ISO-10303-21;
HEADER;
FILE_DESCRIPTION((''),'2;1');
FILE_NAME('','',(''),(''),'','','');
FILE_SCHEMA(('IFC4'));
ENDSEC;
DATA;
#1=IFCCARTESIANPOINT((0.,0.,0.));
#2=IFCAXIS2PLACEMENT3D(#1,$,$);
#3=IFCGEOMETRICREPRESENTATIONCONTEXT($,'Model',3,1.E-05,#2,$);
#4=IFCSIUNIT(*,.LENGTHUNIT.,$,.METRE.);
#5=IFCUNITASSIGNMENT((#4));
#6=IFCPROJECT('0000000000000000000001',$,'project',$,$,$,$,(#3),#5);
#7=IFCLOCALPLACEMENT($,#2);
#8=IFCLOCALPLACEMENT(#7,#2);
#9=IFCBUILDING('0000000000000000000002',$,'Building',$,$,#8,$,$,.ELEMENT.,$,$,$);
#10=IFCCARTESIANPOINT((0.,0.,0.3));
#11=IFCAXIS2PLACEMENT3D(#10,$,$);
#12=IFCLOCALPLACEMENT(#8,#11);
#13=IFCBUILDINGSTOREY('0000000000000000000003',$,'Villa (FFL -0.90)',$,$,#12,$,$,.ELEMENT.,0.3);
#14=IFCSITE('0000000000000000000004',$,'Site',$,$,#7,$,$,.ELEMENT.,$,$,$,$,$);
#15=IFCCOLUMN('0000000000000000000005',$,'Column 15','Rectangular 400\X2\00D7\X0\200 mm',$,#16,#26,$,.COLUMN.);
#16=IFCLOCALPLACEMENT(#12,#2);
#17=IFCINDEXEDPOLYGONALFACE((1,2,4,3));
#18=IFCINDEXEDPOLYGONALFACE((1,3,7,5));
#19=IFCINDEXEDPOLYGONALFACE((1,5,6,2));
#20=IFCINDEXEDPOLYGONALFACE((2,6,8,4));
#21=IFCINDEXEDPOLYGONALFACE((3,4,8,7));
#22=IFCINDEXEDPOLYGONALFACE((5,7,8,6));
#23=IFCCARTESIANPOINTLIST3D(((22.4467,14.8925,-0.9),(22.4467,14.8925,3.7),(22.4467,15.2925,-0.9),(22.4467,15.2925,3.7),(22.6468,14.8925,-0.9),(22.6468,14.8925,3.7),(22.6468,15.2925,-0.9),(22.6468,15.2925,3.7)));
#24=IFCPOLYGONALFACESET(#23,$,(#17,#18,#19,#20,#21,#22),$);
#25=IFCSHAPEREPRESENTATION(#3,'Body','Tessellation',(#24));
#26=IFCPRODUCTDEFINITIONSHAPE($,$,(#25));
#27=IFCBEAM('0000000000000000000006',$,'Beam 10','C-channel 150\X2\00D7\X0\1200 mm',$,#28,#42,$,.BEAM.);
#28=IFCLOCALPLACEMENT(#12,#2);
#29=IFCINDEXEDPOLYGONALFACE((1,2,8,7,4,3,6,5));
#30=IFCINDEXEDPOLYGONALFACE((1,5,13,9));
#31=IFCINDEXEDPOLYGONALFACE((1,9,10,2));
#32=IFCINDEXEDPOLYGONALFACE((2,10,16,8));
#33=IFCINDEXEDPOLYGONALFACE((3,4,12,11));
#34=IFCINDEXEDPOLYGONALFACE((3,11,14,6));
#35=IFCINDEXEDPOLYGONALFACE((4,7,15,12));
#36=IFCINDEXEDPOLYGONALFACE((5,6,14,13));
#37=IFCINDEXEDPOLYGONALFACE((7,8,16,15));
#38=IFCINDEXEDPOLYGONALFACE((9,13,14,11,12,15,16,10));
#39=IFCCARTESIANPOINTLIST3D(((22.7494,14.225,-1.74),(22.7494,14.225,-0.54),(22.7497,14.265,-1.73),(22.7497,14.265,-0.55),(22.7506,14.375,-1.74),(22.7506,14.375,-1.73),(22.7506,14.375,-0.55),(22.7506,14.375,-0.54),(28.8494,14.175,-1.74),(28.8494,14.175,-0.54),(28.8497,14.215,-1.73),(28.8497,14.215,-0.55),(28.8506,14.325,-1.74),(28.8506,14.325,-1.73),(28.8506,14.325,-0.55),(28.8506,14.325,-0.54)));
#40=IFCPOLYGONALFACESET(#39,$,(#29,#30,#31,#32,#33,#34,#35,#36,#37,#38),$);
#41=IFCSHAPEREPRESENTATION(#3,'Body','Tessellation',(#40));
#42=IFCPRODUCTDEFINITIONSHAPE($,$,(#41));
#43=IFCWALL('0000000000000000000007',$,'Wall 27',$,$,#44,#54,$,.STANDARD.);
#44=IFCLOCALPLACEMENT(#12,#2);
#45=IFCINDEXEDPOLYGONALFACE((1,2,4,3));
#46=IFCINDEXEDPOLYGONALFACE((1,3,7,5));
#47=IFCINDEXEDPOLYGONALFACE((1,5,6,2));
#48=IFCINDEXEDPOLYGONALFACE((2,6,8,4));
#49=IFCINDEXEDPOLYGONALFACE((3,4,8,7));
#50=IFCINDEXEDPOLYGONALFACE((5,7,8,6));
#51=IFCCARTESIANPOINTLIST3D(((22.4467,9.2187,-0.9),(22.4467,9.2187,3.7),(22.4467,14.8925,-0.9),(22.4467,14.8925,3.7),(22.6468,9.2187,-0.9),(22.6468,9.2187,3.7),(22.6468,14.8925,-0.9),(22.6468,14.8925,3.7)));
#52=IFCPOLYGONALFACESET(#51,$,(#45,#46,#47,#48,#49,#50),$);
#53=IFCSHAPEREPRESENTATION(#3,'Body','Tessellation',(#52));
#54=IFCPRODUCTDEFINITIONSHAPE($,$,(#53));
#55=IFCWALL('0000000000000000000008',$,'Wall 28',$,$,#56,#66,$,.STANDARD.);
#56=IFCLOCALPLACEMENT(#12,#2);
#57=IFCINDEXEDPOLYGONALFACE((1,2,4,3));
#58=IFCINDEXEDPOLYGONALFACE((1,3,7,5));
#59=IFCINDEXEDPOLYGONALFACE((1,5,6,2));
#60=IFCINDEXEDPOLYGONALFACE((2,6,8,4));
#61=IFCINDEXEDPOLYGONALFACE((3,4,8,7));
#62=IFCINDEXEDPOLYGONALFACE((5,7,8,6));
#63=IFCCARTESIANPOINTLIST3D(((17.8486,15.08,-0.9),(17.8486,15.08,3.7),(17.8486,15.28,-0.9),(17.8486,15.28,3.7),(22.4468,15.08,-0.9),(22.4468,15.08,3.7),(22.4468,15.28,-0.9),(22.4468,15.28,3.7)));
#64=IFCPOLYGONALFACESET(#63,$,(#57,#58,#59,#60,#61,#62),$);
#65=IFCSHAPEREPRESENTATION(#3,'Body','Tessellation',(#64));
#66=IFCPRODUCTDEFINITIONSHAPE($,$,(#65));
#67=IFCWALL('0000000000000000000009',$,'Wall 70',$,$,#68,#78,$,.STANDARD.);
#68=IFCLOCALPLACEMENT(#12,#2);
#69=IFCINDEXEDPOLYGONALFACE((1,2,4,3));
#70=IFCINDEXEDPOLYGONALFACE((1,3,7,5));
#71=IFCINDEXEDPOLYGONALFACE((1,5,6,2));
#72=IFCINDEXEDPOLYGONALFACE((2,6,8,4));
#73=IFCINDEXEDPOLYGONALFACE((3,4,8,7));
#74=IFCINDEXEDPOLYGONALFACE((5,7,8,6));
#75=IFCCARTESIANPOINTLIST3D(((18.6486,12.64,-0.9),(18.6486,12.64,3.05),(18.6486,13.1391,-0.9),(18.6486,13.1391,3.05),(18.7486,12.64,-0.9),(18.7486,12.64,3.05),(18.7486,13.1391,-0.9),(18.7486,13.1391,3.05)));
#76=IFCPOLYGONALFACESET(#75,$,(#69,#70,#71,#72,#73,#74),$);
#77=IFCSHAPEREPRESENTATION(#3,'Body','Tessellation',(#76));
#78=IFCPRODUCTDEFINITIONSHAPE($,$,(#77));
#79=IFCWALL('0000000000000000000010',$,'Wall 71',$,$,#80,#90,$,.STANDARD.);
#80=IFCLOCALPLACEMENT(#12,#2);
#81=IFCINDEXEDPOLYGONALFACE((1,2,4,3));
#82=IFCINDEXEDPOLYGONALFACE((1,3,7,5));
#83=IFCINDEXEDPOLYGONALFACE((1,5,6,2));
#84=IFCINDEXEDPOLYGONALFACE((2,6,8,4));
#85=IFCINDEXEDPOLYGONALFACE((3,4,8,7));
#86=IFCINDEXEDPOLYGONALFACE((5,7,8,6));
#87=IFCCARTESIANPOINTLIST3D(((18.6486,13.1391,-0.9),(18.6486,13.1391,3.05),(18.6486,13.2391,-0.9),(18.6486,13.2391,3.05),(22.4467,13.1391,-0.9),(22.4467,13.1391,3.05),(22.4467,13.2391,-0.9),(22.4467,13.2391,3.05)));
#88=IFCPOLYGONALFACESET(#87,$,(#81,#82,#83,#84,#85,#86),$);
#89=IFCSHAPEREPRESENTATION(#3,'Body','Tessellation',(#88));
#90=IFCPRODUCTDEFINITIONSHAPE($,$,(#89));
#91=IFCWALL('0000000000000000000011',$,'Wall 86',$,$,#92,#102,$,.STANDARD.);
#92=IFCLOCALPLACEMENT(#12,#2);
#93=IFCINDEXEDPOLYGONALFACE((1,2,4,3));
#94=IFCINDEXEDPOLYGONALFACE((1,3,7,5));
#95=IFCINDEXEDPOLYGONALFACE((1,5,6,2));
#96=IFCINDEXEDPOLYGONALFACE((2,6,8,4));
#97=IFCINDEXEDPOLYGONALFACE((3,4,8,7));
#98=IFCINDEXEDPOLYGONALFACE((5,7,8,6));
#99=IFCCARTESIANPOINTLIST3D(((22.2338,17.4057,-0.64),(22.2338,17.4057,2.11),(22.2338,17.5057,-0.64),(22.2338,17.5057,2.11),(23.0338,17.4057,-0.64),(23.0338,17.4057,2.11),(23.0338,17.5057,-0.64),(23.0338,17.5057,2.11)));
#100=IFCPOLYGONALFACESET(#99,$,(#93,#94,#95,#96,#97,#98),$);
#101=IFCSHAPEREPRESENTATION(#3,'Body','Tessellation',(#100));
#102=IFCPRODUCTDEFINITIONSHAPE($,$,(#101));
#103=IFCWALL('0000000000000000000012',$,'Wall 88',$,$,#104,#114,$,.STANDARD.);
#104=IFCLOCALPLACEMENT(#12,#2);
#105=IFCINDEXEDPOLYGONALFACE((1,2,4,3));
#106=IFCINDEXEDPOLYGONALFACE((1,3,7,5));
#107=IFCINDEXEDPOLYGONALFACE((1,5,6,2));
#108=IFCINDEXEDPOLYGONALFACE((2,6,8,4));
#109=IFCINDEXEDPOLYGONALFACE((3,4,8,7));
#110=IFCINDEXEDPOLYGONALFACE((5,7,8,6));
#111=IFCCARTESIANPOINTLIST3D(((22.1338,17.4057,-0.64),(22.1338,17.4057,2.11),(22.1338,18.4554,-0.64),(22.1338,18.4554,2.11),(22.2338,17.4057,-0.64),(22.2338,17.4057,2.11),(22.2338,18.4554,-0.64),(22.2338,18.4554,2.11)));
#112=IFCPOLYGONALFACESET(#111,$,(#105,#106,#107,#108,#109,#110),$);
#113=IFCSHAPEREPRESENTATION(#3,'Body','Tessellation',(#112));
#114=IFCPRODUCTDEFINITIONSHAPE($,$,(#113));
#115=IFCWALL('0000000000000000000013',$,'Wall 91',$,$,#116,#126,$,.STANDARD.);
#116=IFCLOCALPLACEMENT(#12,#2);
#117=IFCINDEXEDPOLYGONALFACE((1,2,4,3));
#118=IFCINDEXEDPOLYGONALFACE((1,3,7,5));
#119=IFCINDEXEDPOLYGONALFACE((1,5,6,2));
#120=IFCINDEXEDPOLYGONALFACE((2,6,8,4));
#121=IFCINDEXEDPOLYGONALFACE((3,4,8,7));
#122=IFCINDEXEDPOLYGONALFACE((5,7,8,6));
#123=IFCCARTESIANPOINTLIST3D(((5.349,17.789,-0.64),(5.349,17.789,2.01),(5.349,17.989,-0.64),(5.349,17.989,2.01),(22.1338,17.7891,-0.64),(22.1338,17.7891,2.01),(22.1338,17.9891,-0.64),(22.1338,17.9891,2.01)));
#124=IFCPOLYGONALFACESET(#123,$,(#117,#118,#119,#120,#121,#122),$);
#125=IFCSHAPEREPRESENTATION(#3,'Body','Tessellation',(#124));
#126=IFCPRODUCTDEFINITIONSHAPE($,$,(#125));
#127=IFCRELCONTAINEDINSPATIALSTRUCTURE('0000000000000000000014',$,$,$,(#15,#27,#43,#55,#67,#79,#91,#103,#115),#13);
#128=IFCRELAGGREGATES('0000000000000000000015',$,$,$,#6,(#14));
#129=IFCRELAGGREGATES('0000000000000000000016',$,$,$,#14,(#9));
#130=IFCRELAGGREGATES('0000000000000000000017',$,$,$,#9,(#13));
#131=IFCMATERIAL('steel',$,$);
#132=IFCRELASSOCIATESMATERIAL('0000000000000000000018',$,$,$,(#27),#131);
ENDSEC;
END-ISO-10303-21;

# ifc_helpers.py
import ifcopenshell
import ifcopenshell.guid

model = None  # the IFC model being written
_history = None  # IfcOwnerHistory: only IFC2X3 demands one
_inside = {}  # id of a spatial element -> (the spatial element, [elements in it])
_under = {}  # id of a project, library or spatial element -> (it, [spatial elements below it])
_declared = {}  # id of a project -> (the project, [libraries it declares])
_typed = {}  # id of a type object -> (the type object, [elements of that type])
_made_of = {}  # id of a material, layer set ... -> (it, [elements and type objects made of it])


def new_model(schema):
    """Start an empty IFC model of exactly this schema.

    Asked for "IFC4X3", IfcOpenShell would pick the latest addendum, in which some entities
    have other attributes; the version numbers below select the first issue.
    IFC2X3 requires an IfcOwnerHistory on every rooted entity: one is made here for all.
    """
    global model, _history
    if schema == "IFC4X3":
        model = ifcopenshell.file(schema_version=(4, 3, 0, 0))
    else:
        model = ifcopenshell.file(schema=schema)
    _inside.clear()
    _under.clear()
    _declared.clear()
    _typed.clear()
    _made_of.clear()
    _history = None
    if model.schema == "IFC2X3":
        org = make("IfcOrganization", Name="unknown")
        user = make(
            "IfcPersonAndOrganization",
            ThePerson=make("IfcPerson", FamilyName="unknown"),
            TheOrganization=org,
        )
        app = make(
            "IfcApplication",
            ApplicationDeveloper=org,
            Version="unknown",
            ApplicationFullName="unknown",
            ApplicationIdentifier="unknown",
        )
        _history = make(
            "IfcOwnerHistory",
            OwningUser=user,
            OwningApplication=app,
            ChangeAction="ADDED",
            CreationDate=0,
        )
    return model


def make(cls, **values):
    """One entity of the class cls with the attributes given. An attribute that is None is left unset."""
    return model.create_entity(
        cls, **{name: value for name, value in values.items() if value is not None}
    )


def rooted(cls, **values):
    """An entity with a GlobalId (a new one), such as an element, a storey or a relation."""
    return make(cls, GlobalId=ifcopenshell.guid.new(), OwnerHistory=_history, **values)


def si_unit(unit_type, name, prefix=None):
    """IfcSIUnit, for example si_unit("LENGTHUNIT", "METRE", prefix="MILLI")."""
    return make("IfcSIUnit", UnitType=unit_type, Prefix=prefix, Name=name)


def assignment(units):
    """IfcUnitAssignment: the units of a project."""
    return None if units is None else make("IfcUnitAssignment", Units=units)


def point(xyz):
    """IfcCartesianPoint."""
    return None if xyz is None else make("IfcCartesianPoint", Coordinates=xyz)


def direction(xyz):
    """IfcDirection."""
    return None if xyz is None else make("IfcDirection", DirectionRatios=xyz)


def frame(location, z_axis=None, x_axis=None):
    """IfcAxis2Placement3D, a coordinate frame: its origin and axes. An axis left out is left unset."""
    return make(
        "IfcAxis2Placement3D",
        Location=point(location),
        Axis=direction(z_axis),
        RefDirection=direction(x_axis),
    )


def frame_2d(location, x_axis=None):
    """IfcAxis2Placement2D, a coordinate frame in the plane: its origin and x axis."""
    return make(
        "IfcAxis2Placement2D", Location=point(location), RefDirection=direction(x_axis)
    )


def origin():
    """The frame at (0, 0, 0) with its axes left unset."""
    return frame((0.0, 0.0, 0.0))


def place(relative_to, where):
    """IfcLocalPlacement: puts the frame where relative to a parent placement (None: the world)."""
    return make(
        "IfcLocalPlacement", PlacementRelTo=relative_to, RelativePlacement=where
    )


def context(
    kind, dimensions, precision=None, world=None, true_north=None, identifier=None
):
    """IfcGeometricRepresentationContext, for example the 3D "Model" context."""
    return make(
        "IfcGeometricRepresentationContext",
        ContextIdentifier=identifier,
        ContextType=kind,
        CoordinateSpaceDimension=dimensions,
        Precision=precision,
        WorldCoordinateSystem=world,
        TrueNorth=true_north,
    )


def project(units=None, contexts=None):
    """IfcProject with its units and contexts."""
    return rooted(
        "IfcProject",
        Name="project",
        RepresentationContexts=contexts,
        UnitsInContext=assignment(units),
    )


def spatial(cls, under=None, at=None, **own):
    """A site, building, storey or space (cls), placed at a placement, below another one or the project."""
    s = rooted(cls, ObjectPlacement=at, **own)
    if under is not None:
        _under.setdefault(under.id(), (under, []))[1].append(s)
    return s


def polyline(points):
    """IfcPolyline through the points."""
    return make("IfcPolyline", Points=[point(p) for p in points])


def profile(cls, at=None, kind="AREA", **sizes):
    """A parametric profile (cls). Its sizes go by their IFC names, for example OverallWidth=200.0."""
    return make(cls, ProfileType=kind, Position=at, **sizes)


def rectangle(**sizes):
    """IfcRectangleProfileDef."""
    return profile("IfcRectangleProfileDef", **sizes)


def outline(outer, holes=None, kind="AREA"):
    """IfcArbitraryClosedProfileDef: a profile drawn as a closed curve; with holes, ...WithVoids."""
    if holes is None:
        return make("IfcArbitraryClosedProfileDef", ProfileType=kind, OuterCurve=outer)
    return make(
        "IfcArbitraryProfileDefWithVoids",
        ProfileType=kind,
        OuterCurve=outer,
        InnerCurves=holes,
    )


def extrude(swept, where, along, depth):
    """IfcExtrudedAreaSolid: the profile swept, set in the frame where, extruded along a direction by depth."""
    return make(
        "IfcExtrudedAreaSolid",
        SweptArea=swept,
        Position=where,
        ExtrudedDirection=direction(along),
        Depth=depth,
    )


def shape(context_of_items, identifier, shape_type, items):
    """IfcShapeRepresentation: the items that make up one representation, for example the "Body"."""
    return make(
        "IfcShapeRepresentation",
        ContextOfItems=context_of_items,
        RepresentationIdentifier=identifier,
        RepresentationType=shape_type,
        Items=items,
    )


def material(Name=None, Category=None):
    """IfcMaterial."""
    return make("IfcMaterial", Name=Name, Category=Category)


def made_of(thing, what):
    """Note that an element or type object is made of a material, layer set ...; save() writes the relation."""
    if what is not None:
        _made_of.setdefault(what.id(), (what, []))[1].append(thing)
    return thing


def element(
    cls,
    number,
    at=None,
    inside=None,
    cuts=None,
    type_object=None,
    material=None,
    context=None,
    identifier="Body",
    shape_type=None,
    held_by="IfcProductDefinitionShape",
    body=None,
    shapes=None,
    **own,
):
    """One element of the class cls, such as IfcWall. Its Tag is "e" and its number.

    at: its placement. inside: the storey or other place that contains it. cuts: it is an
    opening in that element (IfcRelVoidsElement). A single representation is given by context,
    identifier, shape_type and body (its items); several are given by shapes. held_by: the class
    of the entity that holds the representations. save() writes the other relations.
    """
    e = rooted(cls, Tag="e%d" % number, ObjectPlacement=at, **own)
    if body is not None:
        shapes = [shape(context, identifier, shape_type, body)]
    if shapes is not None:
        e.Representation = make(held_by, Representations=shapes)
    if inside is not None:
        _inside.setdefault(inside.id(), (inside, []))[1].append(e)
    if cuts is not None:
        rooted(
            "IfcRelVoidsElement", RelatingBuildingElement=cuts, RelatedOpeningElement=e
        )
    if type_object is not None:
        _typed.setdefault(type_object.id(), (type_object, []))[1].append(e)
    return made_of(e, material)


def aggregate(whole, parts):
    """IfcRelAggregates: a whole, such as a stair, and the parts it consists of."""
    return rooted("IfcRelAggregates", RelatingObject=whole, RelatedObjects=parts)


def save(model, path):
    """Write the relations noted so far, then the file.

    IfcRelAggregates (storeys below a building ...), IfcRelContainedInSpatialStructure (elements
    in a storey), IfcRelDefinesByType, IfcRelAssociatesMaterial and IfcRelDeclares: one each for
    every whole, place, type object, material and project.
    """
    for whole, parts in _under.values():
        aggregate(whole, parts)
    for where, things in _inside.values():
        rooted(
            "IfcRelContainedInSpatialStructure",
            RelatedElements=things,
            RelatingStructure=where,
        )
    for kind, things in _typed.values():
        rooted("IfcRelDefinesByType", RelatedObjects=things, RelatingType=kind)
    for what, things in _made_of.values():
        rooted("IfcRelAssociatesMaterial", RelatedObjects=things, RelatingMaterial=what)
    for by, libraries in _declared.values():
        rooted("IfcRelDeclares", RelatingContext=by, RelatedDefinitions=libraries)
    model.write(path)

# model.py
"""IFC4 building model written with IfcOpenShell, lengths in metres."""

from ifc_helpers import new_model, si_unit, frame, frame_2d, origin, place, context, project, spatial, polyline, rectangle, outline, extrude, material, element, save


model = new_model("IFC4")

# Units and contexts
model_context = context("Model", 3, precision=1e-05, world=origin())
ifc_project = project(units=[si_unit("LENGTHUNIT", "METRE")], contexts=[model_context])

# Site, building, storey
site_placement = place(None, origin())
site = spatial("IfcSite", under=ifc_project, at=site_placement, Name="Site", CompositionType="ELEMENT")
building_placement = place(site_placement, origin())
building = spatial("IfcBuilding", under=site, at=building_placement, Name="Building", CompositionType="ELEMENT")
storey_placement = place(building_placement, frame((0.0, 0.0, 0.3)))
storey = spatial("IfcBuildingStorey", under=building, at=storey_placement, Name="Villa (FFL -0.90)", CompositionType="ELEMENT", Elevation=0.3)

# Column
column_placement = place(storey_placement, frame((22.5467, 15.0925, -0.9), z_axis=(0.0, 0.0, 1.0), x_axis=(0.0, 1.0, 0.0)))
element("IfcColumn", 1, at=column_placement, inside=storey, Name="Column 15", Description="Rectangular 400×200 mm", PredefinedType="COLUMN", context=model_context, shape_type="SweptSolid", body=[
    extrude(outline(polyline([(-0.2, -0.1), (0.2, -0.1), (0.2, 0.1), (-0.2, 0.1), (-0.2, -0.1)])), origin(), (0.0, 0.0, 1.0), 4.6),
])

# Beam
ifc_material = material(Name="steel")
beam_placement = place(storey_placement, frame((22.75, 14.3, -1.14), z_axis=(0.999966, -0.008196, 0.0), x_axis=(0.008196, 0.999966, 0.0)))
element("IfcBeam", 2, at=beam_placement, inside=storey, material=ifc_material, Name="Beam 10", Description="C-channel 150×1200 mm", PredefinedType="BEAM", context=model_context, shape_type="SweptSolid", body=[
    extrude(outline(polyline([(-0.075, -0.6), (0.075, -0.6), (0.075, -0.59), (-0.035, -0.59), (-0.035, 0.59), (0.075, 0.59), (0.075, 0.6), (-0.075, 0.6), (-0.075, -0.6)])), origin(), (0.0, 0.0, 1.0), 6.1002),
])

# Walls
wall_1_placement = place(storey_placement, frame((22.5467, 14.8925, -0.9), z_axis=(0.0, 0.0, 1.0), x_axis=(0.0, -1.0, 0.0)))
element("IfcWall", 3, at=wall_1_placement, inside=storey, Name="Wall 27", PredefinedType="STANDARD", context=model_context, shape_type="SweptSolid", body=[
    extrude(rectangle(XDim=5.6738, YDim=0.2, at=frame_2d((2.8369, 0.0))), origin(), (0.0, 0.0, 1.0), 4.6),
])
wall_2_placement = place(storey_placement, frame((17.8486, 15.18, -0.9), z_axis=(0.0, 0.0, 1.0), x_axis=(1.0, 0.0, 0.0)))
element("IfcWall", 4, at=wall_2_placement, inside=storey, Name="Wall 28", PredefinedType="STANDARD", context=model_context, shape_type="SweptSolid", body=[
    extrude(rectangle(XDim=4.5982, YDim=0.2, at=frame_2d((2.2991, 0.0))), origin(), (0.0, 0.0, 1.0), 4.6),
])
wall_3_placement = place(storey_placement, frame((18.6986, 13.1391, -0.9), z_axis=(0.0, 0.0, 1.0), x_axis=(0.0, -1.0, 0.0)))
element("IfcWall", 5, at=wall_3_placement, inside=storey, Name="Wall 70", PredefinedType="STANDARD", context=model_context, shape_type="SweptSolid", body=[
    extrude(rectangle(XDim=0.4991, YDim=0.1, at=frame_2d((0.2495, 0.0))), origin(), (0.0, 0.0, 1.0), 3.95),
])
wall_4_placement = place(storey_placement, frame((18.6486, 13.1891, -0.9), z_axis=(0.0, 0.0, 1.0), x_axis=(1.0, 0.0, 0.0)))
element("IfcWall", 6, at=wall_4_placement, inside=storey, Name="Wall 71", PredefinedType="STANDARD", context=model_context, shape_type="SweptSolid", body=[
    extrude(rectangle(XDim=3.7982, YDim=0.1, at=frame_2d((1.8991, 0.0))), origin(), (0.0, 0.0, 1.0), 3.95),
])

# Walls
wall_5_placement = place(storey_placement, frame((23.0338, 17.4557, -0.64), z_axis=(0.0, 0.0, 1.0), x_axis=(-1.0, 0.0, 0.0)))
element("IfcWall", 7, at=wall_5_placement, inside=storey, Name="Wall 86", PredefinedType="STANDARD", context=model_context, shape_type="SweptSolid", body=[
    extrude(rectangle(XDim=0.8, YDim=0.1, at=frame_2d((0.4, 0.0))), origin(), (0.0, 0.0, 1.0), 2.75),
])
wall_6_placement = place(storey_placement, frame((22.1838, 17.4057, -0.64), z_axis=(0.0, 0.0, 1.0), x_axis=(0.0, 1.0, 0.0)))
element("IfcWall", 8, at=wall_6_placement, inside=storey, Name="Wall 88", PredefinedType="STANDARD", context=model_context, shape_type="SweptSolid", body=[
    extrude(rectangle(XDim=1.0497, YDim=0.1, at=frame_2d((0.5249, 0.0))), origin(), (0.0, 0.0, 1.0), 2.75),
])
wall_7_placement = place(storey_placement, frame((22.1338, 17.8891, -0.64), z_axis=(0.0, 0.0, 1.0), x_axis=(-1.0, -0.000006, 0.0)))
element("IfcWall", 9, at=wall_7_placement, inside=storey, Name="Wall 91", PredefinedType="STANDARD", context=model_context, shape_type="SweptSolid", body=[
    extrude(rectangle(XDim=16.7848, YDim=0.2, at=frame_2d((8.3924, 0.0))), origin(), (0.0, 0.0, 1.0), 2.65),
])

save(model, "model.ifc")
